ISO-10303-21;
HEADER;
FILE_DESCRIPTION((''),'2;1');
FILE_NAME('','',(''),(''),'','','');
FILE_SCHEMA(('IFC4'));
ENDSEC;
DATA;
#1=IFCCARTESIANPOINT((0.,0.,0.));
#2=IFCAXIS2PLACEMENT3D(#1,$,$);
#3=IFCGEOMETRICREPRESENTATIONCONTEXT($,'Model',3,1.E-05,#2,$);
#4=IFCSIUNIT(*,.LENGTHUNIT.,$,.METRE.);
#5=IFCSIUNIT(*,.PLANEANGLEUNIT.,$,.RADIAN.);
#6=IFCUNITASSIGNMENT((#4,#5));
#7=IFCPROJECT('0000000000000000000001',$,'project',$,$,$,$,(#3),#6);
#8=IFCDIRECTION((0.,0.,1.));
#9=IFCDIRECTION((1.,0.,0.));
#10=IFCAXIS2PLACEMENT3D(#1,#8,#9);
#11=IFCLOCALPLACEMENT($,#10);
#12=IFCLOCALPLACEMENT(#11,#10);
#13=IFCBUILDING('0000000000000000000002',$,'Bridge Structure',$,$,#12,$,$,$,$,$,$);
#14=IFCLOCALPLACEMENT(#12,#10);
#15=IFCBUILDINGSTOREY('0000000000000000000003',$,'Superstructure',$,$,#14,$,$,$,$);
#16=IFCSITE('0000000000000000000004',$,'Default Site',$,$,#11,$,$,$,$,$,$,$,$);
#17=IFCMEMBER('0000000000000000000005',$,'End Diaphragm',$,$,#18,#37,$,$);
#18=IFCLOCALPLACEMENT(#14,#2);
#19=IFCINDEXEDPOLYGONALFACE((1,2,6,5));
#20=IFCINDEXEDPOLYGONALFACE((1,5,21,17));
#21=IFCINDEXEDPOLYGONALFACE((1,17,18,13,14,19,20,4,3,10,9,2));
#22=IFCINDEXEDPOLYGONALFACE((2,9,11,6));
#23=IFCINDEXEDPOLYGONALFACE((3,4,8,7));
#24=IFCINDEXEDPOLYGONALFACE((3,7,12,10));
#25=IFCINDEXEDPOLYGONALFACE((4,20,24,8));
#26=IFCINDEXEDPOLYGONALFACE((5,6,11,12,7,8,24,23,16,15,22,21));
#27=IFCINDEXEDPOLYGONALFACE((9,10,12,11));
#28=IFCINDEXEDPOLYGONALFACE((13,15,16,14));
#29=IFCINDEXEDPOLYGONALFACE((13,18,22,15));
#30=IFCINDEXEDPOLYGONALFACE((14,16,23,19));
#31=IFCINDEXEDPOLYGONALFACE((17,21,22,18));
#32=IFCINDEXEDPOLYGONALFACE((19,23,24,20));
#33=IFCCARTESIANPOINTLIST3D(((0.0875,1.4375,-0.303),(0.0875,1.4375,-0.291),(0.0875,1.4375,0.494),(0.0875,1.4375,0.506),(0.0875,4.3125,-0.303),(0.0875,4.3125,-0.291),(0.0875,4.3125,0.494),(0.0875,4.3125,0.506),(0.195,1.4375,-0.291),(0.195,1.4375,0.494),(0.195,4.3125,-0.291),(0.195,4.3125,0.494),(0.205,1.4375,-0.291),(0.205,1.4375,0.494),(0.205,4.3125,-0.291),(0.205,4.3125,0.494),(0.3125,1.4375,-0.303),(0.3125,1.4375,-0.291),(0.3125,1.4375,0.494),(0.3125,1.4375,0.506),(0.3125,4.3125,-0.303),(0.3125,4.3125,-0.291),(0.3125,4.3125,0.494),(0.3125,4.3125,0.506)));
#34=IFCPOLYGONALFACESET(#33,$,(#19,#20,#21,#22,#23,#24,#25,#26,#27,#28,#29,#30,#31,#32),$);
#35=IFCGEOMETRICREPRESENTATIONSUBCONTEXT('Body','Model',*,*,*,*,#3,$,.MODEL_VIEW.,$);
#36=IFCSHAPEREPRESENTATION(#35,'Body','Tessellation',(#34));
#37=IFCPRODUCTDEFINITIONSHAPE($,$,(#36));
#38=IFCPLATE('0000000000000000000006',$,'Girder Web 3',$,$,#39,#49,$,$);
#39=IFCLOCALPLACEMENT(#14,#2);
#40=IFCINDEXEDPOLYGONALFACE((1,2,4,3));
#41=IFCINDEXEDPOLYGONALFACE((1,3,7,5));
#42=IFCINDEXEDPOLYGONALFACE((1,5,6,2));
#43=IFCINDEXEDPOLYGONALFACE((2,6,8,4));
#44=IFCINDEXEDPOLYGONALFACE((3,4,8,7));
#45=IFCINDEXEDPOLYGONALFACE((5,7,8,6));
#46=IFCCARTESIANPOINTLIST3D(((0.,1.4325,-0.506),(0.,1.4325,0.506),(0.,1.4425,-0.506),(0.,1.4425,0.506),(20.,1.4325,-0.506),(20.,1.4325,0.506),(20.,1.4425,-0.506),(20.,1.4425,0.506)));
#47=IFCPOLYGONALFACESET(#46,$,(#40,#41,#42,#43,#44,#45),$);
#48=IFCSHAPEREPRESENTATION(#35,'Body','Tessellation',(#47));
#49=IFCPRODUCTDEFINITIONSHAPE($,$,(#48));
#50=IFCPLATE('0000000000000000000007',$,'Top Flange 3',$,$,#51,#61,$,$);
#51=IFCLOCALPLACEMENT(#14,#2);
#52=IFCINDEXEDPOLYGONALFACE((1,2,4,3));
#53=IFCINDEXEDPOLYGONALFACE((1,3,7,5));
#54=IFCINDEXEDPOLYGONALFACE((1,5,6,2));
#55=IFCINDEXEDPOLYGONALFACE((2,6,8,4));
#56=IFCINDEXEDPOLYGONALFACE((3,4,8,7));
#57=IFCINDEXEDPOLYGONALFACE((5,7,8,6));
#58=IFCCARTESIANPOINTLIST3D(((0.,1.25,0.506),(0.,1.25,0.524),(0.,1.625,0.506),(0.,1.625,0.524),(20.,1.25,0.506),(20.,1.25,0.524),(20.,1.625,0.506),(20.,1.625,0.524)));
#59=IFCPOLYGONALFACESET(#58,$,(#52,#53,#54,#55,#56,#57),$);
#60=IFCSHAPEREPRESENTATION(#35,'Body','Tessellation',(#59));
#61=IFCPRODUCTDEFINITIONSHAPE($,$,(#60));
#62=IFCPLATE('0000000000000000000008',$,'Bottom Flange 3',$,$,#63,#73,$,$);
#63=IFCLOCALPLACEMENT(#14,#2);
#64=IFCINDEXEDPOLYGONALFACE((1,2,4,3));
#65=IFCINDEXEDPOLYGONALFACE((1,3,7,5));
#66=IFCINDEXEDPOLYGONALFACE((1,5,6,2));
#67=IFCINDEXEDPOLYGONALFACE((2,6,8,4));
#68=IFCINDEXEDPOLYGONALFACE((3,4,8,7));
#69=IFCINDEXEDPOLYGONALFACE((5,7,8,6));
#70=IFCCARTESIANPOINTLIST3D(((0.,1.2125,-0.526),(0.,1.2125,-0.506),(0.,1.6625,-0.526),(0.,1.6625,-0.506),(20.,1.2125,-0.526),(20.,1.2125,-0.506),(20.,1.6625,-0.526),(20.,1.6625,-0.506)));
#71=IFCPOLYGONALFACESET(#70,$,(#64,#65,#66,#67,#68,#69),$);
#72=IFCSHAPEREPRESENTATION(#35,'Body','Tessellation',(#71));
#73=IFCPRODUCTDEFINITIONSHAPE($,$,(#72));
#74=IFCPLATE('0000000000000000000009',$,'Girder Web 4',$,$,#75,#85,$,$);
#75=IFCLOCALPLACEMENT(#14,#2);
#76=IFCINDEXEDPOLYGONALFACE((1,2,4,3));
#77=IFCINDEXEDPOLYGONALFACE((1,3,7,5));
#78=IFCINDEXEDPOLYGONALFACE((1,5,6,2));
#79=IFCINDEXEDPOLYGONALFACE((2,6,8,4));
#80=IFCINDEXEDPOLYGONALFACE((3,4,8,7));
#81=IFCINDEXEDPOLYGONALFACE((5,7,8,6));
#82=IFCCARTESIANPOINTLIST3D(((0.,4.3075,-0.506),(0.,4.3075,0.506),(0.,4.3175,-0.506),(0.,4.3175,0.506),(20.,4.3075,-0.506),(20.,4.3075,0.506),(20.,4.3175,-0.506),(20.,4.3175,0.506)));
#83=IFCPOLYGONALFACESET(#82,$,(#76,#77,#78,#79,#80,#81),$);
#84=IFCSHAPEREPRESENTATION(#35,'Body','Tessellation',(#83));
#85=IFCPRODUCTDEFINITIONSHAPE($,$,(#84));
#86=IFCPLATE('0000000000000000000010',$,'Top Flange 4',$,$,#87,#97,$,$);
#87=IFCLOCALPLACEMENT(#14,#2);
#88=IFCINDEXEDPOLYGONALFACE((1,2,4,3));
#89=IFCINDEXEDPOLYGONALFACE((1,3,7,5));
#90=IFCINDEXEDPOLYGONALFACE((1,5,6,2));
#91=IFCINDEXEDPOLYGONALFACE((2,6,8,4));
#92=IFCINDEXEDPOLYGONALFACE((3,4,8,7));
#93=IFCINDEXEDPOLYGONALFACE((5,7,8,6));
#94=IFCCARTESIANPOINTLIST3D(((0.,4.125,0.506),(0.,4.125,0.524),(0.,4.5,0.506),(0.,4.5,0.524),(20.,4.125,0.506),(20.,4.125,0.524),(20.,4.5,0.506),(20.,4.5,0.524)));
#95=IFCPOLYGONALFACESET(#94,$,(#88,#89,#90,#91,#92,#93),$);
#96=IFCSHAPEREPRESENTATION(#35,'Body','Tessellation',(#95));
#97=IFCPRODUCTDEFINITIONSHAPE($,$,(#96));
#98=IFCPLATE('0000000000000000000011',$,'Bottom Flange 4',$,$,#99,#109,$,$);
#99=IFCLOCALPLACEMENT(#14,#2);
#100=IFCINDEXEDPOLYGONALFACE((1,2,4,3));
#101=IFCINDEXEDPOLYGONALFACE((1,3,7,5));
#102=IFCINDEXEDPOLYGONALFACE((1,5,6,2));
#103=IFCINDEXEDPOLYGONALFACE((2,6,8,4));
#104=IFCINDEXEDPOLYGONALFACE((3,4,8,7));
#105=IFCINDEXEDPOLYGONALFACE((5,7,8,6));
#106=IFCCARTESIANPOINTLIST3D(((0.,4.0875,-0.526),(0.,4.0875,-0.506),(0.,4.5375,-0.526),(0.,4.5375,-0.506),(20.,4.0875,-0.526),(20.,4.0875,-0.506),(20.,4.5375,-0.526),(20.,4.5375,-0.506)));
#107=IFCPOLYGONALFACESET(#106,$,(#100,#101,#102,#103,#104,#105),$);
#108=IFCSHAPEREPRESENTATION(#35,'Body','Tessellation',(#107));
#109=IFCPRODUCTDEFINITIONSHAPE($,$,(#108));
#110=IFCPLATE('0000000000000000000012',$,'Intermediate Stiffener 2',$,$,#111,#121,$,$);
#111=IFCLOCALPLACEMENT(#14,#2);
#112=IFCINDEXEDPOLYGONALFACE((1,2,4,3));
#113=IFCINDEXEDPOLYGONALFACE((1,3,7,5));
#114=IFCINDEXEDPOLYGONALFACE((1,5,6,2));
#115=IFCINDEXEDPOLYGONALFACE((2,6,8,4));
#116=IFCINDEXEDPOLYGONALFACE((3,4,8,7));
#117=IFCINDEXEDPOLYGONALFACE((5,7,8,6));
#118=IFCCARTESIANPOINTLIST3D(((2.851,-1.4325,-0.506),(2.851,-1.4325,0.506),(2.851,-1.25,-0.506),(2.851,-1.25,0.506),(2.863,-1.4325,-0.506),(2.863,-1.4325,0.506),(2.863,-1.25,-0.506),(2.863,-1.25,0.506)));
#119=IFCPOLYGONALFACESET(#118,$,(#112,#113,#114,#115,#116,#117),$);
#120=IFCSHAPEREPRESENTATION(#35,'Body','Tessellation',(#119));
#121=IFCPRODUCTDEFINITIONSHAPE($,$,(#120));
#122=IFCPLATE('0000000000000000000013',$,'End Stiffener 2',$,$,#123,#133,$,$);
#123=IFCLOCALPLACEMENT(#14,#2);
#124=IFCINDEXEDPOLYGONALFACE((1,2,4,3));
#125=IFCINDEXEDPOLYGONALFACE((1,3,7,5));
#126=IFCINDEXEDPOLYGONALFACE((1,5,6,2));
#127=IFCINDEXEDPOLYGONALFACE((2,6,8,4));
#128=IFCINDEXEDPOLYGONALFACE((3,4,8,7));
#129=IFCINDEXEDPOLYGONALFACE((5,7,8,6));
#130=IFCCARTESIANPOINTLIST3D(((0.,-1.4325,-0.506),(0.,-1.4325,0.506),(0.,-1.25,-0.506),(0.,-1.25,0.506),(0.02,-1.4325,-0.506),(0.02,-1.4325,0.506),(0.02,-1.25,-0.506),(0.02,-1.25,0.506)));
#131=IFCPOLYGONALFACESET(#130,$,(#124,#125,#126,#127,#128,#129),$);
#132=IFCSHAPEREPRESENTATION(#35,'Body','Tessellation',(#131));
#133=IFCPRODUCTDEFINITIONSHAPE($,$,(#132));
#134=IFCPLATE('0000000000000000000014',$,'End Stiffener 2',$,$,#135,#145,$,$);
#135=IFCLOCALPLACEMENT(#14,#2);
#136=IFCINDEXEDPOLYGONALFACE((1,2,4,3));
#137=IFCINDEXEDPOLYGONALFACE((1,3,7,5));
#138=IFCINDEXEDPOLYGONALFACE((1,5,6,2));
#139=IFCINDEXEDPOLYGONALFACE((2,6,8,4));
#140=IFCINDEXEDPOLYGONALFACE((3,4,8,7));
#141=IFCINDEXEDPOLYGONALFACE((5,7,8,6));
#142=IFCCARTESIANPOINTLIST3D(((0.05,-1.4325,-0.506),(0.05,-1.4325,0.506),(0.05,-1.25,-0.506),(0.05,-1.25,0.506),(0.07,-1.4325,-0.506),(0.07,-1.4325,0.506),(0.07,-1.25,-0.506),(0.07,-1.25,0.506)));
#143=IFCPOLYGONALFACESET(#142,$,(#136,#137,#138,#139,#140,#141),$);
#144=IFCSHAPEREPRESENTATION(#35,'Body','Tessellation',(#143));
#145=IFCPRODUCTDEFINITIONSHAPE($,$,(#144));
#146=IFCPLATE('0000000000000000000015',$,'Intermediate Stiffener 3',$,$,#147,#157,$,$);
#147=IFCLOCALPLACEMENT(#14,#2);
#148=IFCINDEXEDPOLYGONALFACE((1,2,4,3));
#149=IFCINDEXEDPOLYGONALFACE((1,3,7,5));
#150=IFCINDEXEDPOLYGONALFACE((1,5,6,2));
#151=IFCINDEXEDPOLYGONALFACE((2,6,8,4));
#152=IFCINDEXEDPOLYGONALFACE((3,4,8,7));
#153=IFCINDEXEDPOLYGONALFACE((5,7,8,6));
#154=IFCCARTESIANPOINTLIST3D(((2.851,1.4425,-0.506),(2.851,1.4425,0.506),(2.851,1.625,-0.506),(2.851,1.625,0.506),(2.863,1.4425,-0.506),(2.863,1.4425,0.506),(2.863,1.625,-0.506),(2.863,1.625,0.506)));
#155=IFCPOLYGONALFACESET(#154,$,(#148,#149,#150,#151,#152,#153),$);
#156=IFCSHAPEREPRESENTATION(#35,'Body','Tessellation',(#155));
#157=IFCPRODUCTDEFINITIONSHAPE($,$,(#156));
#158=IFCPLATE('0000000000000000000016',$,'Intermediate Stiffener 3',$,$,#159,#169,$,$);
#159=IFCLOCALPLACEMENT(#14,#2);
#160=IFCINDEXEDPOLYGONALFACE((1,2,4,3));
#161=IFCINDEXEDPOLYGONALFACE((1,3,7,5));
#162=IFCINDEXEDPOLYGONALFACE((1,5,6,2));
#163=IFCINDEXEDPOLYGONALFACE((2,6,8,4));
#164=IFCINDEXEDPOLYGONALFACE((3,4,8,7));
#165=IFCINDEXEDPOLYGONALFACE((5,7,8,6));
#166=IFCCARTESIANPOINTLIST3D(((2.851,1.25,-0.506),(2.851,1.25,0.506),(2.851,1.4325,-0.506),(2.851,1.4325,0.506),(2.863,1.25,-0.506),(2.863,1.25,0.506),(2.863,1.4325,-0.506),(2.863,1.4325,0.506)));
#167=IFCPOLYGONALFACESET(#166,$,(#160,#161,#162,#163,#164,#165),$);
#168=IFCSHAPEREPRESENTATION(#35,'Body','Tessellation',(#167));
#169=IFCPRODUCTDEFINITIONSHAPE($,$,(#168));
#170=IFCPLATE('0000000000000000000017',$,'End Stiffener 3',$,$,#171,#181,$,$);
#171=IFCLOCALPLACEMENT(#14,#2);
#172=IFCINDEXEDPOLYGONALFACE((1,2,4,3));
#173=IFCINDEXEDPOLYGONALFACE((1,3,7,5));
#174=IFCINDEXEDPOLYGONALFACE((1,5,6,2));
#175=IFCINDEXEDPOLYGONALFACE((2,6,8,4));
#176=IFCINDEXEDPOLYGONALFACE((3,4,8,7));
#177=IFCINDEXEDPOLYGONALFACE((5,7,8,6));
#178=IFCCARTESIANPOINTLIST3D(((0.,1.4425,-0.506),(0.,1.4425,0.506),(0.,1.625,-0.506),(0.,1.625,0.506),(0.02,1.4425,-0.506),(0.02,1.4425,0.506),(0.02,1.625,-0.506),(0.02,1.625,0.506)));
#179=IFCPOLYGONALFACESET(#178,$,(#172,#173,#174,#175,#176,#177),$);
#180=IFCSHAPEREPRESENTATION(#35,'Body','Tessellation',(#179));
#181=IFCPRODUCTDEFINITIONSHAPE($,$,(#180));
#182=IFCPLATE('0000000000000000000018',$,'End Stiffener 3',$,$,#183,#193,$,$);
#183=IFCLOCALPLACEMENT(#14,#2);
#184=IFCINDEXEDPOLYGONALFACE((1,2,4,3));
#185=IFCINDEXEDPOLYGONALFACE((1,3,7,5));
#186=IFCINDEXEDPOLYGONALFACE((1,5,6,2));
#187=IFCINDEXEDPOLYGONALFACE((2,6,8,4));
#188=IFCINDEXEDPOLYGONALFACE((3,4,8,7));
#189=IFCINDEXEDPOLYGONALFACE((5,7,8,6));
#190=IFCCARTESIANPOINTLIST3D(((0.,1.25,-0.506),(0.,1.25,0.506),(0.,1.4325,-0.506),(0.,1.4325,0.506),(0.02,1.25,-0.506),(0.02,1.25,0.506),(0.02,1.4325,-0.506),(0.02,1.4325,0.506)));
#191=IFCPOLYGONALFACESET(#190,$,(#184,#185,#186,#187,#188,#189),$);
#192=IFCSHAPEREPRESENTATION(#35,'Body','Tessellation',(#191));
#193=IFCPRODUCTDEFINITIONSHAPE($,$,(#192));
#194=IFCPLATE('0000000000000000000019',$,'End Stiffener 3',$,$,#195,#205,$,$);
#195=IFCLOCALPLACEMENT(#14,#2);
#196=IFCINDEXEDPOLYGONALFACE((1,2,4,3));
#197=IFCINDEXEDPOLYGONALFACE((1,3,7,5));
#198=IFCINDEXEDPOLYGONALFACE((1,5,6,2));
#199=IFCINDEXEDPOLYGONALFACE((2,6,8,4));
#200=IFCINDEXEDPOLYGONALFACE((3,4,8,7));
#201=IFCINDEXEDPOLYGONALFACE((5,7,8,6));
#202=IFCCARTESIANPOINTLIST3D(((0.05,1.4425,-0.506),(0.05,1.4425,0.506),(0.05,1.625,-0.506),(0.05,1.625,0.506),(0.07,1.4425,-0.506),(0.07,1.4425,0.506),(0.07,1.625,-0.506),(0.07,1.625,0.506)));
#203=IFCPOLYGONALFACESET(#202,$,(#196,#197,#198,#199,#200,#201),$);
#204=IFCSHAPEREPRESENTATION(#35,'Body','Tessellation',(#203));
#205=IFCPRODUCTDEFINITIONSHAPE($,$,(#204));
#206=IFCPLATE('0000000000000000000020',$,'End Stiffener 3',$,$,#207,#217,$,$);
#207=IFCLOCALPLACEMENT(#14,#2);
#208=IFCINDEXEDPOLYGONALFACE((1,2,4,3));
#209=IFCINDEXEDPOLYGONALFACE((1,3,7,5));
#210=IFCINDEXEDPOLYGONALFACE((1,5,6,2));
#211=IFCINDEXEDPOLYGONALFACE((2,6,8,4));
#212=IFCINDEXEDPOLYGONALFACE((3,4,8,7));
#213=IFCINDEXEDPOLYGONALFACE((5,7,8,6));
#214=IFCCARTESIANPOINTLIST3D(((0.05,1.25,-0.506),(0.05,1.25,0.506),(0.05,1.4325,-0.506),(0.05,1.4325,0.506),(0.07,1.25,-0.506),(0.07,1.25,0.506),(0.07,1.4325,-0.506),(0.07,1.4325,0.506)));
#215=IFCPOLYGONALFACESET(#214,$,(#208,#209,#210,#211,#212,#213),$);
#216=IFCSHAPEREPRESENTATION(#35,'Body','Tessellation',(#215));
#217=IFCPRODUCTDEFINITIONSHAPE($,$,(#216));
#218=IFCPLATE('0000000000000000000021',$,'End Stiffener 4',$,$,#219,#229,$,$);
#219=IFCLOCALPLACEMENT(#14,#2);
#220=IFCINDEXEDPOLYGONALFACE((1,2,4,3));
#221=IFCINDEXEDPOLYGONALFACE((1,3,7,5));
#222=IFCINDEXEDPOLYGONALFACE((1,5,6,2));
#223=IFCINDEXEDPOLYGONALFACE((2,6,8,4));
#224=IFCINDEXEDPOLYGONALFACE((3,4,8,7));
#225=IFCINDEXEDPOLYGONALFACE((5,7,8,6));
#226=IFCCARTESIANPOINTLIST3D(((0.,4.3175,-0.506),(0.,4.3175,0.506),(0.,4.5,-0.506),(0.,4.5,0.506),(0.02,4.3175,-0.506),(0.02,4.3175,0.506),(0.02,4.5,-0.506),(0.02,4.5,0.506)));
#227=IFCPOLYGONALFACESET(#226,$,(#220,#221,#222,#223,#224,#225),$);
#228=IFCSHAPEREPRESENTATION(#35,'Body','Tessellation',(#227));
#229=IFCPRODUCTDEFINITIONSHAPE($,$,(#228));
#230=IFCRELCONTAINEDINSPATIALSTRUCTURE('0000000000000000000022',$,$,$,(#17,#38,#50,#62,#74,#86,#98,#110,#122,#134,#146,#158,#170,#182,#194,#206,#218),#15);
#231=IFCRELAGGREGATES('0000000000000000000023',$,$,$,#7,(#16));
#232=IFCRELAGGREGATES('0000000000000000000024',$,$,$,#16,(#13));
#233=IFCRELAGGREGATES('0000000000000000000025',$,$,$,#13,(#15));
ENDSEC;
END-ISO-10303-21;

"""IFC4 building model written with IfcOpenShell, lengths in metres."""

from ifc_helpers import new_model, si_unit, frame, origin, origin_with_axes, origin_2d_with_axis, place, context, subcontext, project, spatial, rectangle, i_section, extrude, element, save


model = new_model("IFC4")

# Units and contexts
model_context = context("Model", 3, precision=1e-05, world=origin())
body_context = subcontext(model_context, "Body", "Model", "MODEL_VIEW")
ifc_project = project(units=[si_unit("LENGTHUNIT", "METRE"), si_unit("PLANEANGLEUNIT", "RADIAN")], contexts=[model_context])

# Site, building, storey
site_placement = place(None, origin_with_axes())
site = spatial("IfcSite", under=ifc_project, at=site_placement, Name="Default Site")
building_placement = place(site_placement, origin_with_axes())
building = spatial("IfcBuilding", under=site, at=building_placement, Name="Bridge Structure")
storey_placement = place(building_placement, origin_with_axes())
storey = spatial("IfcBuildingStorey", under=building, at=storey_placement, Name="Superstructure")

# Member
member_placement = place(storey_placement, frame((0.2, 1.4375, 0.1015), z_axis=(0.0, 1.0, 0.0), x_axis=(-1.0, 0.0, 0.0)))
element("IfcMember", 1, at=member_placement, inside=storey, Name="End Diaphragm", context=body_context, shape_type="SweptSolid", body=[
    extrude(i_section(OverallWidth=0.225, OverallDepth=0.809, WebThickness=0.01, FlangeThickness=0.012, at=origin_2d_with_axis()), origin_with_axes(), (0.0, 0.0, 1.0), 2.875),
])

# Plates
plate_1_placement = place(storey_placement, frame((0.0, 1.4375, 0.0), z_axis=(1.0, 0.0, 0.0), x_axis=(0.0, 1.0, 0.0)))
element("IfcPlate", 2, at=plate_1_placement, inside=storey, Name="Girder Web 3", context=body_context, shape_type="SweptSolid", body=[
    extrude(rectangle(XDim=0.01, YDim=1.012, at=origin_2d_with_axis()), origin_with_axes(), (0.0, 0.0, 1.0), 20.0),
])
plate_2_placement = place(storey_placement, frame((0.0, 1.4375, 0.515), z_axis=(1.0, 0.0, 0.0), x_axis=(0.0, 1.0, 0.0)))
element("IfcPlate", 3, at=plate_2_placement, inside=storey, Name="Top Flange 3", context=body_context, shape_type="SweptSolid", body=[
    extrude(rectangle(XDim=0.375, YDim=0.018, at=origin_2d_with_axis()), origin_with_axes(), (0.0, 0.0, 1.0), 20.0),
])
plate_3_placement = place(storey_placement, frame((0.0, 1.4375, -0.516), z_axis=(1.0, 0.0, 0.0), x_axis=(0.0, 1.0, 0.0)))
element("IfcPlate", 4, at=plate_3_placement, inside=storey, Name="Bottom Flange 3", context=body_context, shape_type="SweptSolid", body=[
    extrude(rectangle(XDim=0.45, YDim=0.02, at=origin_2d_with_axis()), origin_with_axes(), (0.0, 0.0, 1.0), 20.0),
])
plate_4_placement = place(storey_placement, frame((0.0, 4.3125, 0.0), z_axis=(1.0, 0.0, 0.0), x_axis=(0.0, 1.0, 0.0)))
element("IfcPlate", 5, at=plate_4_placement, inside=storey, Name="Girder Web 4", context=body_context, shape_type="SweptSolid", body=[
    extrude(rectangle(XDim=0.01, YDim=1.012, at=origin_2d_with_axis()), origin_with_axes(), (0.0, 0.0, 1.0), 20.0),
])
plate_5_placement = place(storey_placement, frame((0.0, 4.3125, 0.515), z_axis=(1.0, 0.0, 0.0), x_axis=(0.0, 1.0, 0.0)))
element("IfcPlate", 6, at=plate_5_placement, inside=storey, Name="Top Flange 4", context=body_context, shape_type="SweptSolid", body=[
    extrude(rectangle(XDim=0.375, YDim=0.018, at=origin_2d_with_axis()), origin_with_axes(), (0.0, 0.0, 1.0), 20.0),
])
plate_6_placement = place(storey_placement, frame((0.0, 4.3125, -0.516), z_axis=(1.0, 0.0, 0.0), x_axis=(0.0, 1.0, 0.0)))
element("IfcPlate", 7, at=plate_6_placement, inside=storey, Name="Bottom Flange 4", context=body_context, shape_type="SweptSolid", body=[
    extrude(rectangle(XDim=0.45, YDim=0.02, at=origin_2d_with_axis()), origin_with_axes(), (0.0, 0.0, 1.0), 20.0),
])
plate_7_placement = place(storey_placement, frame((2.857, -1.3413, -0.506), z_axis=(0.0, 0.0, 1.0), x_axis=(1.0, 0.0, 0.0)))
element("IfcPlate", 8, at=plate_7_placement, inside=storey, Name="Intermediate Stiffener 2", context=body_context, shape_type="SweptSolid", body=[
    extrude(rectangle(XDim=0.012, YDim=0.1825, at=origin_2d_with_axis()), origin_with_axes(), (0.0, 0.0, 1.0), 1.012),
])
for number, where, z_axis, x_axis, name in (
    (9, (0.01, -1.3413, -0.506), (0.0, 0.0, 1.0), (1.0, 0.0, 0.0), "End Stiffener 2"),
    (10, (0.06, -1.3413, -0.506), (0.0, 0.0, 1.0), (1.0, 0.0, 0.0), "End Stiffener 2"),
):
    element("IfcPlate", number, at=place(storey_placement, frame(where, z_axis=z_axis, x_axis=x_axis)), inside=storey, Name=name, context=body_context, shape_type="SweptSolid", body=[
        extrude(rectangle(XDim=0.02, YDim=0.1825, at=origin_2d_with_axis()), origin_with_axes(), (0.0, 0.0, 1.0), 1.012),
    ])
for number, where, z_axis, x_axis, name in (
    (11, (2.857, 1.5337, -0.506), (0.0, 0.0, 1.0), (1.0, 0.0, 0.0), "Intermediate Stiffener 3"),
    (12, (2.857, 1.3413, -0.506), (0.0, 0.0, 1.0), (1.0, 0.0, 0.0), "Intermediate Stiffener 3"),
):
    element("IfcPlate", number, at=place(storey_placement, frame(where, z_axis=z_axis, x_axis=x_axis)), inside=storey, Name=name, context=body_context, shape_type="SweptSolid", body=[
        extrude(rectangle(XDim=0.012, YDim=0.1825, at=origin_2d_with_axis()), origin_with_axes(), (0.0, 0.0, 1.0), 1.012),
    ])
for number, where, z_axis, x_axis, name in (
    (13, (0.01, 1.5337, -0.506), (0.0, 0.0, 1.0), (1.0, 0.0, 0.0), "End Stiffener 3"),
    (14, (0.01, 1.3413, -0.506), (0.0, 0.0, 1.0), (1.0, 0.0, 0.0), "End Stiffener 3"),
    (15, (0.06, 1.5337, -0.506), (0.0, 0.0, 1.0), (1.0, 0.0, 0.0), "End Stiffener 3"),
    (16, (0.06, 1.3413, -0.506), (0.0, 0.0, 1.0), (1.0, 0.0, 0.0), "End Stiffener 3"),
    (17, (0.01, 4.4088, -0.506), (0.0, 0.0, 1.0), (1.0, 0.0, 0.0), "End Stiffener 4"),
):
    element("IfcPlate", number, at=place(storey_placement, frame(where, z_axis=z_axis, x_axis=x_axis)), inside=storey, Name=name, context=body_context, shape_type="SweptSolid", body=[
        extrude(rectangle(XDim=0.02, YDim=0.1825, at=origin_2d_with_axis()), origin_with_axes(), (0.0, 0.0, 1.0), 1.012),
    ])

save(model, "model.ifc")
